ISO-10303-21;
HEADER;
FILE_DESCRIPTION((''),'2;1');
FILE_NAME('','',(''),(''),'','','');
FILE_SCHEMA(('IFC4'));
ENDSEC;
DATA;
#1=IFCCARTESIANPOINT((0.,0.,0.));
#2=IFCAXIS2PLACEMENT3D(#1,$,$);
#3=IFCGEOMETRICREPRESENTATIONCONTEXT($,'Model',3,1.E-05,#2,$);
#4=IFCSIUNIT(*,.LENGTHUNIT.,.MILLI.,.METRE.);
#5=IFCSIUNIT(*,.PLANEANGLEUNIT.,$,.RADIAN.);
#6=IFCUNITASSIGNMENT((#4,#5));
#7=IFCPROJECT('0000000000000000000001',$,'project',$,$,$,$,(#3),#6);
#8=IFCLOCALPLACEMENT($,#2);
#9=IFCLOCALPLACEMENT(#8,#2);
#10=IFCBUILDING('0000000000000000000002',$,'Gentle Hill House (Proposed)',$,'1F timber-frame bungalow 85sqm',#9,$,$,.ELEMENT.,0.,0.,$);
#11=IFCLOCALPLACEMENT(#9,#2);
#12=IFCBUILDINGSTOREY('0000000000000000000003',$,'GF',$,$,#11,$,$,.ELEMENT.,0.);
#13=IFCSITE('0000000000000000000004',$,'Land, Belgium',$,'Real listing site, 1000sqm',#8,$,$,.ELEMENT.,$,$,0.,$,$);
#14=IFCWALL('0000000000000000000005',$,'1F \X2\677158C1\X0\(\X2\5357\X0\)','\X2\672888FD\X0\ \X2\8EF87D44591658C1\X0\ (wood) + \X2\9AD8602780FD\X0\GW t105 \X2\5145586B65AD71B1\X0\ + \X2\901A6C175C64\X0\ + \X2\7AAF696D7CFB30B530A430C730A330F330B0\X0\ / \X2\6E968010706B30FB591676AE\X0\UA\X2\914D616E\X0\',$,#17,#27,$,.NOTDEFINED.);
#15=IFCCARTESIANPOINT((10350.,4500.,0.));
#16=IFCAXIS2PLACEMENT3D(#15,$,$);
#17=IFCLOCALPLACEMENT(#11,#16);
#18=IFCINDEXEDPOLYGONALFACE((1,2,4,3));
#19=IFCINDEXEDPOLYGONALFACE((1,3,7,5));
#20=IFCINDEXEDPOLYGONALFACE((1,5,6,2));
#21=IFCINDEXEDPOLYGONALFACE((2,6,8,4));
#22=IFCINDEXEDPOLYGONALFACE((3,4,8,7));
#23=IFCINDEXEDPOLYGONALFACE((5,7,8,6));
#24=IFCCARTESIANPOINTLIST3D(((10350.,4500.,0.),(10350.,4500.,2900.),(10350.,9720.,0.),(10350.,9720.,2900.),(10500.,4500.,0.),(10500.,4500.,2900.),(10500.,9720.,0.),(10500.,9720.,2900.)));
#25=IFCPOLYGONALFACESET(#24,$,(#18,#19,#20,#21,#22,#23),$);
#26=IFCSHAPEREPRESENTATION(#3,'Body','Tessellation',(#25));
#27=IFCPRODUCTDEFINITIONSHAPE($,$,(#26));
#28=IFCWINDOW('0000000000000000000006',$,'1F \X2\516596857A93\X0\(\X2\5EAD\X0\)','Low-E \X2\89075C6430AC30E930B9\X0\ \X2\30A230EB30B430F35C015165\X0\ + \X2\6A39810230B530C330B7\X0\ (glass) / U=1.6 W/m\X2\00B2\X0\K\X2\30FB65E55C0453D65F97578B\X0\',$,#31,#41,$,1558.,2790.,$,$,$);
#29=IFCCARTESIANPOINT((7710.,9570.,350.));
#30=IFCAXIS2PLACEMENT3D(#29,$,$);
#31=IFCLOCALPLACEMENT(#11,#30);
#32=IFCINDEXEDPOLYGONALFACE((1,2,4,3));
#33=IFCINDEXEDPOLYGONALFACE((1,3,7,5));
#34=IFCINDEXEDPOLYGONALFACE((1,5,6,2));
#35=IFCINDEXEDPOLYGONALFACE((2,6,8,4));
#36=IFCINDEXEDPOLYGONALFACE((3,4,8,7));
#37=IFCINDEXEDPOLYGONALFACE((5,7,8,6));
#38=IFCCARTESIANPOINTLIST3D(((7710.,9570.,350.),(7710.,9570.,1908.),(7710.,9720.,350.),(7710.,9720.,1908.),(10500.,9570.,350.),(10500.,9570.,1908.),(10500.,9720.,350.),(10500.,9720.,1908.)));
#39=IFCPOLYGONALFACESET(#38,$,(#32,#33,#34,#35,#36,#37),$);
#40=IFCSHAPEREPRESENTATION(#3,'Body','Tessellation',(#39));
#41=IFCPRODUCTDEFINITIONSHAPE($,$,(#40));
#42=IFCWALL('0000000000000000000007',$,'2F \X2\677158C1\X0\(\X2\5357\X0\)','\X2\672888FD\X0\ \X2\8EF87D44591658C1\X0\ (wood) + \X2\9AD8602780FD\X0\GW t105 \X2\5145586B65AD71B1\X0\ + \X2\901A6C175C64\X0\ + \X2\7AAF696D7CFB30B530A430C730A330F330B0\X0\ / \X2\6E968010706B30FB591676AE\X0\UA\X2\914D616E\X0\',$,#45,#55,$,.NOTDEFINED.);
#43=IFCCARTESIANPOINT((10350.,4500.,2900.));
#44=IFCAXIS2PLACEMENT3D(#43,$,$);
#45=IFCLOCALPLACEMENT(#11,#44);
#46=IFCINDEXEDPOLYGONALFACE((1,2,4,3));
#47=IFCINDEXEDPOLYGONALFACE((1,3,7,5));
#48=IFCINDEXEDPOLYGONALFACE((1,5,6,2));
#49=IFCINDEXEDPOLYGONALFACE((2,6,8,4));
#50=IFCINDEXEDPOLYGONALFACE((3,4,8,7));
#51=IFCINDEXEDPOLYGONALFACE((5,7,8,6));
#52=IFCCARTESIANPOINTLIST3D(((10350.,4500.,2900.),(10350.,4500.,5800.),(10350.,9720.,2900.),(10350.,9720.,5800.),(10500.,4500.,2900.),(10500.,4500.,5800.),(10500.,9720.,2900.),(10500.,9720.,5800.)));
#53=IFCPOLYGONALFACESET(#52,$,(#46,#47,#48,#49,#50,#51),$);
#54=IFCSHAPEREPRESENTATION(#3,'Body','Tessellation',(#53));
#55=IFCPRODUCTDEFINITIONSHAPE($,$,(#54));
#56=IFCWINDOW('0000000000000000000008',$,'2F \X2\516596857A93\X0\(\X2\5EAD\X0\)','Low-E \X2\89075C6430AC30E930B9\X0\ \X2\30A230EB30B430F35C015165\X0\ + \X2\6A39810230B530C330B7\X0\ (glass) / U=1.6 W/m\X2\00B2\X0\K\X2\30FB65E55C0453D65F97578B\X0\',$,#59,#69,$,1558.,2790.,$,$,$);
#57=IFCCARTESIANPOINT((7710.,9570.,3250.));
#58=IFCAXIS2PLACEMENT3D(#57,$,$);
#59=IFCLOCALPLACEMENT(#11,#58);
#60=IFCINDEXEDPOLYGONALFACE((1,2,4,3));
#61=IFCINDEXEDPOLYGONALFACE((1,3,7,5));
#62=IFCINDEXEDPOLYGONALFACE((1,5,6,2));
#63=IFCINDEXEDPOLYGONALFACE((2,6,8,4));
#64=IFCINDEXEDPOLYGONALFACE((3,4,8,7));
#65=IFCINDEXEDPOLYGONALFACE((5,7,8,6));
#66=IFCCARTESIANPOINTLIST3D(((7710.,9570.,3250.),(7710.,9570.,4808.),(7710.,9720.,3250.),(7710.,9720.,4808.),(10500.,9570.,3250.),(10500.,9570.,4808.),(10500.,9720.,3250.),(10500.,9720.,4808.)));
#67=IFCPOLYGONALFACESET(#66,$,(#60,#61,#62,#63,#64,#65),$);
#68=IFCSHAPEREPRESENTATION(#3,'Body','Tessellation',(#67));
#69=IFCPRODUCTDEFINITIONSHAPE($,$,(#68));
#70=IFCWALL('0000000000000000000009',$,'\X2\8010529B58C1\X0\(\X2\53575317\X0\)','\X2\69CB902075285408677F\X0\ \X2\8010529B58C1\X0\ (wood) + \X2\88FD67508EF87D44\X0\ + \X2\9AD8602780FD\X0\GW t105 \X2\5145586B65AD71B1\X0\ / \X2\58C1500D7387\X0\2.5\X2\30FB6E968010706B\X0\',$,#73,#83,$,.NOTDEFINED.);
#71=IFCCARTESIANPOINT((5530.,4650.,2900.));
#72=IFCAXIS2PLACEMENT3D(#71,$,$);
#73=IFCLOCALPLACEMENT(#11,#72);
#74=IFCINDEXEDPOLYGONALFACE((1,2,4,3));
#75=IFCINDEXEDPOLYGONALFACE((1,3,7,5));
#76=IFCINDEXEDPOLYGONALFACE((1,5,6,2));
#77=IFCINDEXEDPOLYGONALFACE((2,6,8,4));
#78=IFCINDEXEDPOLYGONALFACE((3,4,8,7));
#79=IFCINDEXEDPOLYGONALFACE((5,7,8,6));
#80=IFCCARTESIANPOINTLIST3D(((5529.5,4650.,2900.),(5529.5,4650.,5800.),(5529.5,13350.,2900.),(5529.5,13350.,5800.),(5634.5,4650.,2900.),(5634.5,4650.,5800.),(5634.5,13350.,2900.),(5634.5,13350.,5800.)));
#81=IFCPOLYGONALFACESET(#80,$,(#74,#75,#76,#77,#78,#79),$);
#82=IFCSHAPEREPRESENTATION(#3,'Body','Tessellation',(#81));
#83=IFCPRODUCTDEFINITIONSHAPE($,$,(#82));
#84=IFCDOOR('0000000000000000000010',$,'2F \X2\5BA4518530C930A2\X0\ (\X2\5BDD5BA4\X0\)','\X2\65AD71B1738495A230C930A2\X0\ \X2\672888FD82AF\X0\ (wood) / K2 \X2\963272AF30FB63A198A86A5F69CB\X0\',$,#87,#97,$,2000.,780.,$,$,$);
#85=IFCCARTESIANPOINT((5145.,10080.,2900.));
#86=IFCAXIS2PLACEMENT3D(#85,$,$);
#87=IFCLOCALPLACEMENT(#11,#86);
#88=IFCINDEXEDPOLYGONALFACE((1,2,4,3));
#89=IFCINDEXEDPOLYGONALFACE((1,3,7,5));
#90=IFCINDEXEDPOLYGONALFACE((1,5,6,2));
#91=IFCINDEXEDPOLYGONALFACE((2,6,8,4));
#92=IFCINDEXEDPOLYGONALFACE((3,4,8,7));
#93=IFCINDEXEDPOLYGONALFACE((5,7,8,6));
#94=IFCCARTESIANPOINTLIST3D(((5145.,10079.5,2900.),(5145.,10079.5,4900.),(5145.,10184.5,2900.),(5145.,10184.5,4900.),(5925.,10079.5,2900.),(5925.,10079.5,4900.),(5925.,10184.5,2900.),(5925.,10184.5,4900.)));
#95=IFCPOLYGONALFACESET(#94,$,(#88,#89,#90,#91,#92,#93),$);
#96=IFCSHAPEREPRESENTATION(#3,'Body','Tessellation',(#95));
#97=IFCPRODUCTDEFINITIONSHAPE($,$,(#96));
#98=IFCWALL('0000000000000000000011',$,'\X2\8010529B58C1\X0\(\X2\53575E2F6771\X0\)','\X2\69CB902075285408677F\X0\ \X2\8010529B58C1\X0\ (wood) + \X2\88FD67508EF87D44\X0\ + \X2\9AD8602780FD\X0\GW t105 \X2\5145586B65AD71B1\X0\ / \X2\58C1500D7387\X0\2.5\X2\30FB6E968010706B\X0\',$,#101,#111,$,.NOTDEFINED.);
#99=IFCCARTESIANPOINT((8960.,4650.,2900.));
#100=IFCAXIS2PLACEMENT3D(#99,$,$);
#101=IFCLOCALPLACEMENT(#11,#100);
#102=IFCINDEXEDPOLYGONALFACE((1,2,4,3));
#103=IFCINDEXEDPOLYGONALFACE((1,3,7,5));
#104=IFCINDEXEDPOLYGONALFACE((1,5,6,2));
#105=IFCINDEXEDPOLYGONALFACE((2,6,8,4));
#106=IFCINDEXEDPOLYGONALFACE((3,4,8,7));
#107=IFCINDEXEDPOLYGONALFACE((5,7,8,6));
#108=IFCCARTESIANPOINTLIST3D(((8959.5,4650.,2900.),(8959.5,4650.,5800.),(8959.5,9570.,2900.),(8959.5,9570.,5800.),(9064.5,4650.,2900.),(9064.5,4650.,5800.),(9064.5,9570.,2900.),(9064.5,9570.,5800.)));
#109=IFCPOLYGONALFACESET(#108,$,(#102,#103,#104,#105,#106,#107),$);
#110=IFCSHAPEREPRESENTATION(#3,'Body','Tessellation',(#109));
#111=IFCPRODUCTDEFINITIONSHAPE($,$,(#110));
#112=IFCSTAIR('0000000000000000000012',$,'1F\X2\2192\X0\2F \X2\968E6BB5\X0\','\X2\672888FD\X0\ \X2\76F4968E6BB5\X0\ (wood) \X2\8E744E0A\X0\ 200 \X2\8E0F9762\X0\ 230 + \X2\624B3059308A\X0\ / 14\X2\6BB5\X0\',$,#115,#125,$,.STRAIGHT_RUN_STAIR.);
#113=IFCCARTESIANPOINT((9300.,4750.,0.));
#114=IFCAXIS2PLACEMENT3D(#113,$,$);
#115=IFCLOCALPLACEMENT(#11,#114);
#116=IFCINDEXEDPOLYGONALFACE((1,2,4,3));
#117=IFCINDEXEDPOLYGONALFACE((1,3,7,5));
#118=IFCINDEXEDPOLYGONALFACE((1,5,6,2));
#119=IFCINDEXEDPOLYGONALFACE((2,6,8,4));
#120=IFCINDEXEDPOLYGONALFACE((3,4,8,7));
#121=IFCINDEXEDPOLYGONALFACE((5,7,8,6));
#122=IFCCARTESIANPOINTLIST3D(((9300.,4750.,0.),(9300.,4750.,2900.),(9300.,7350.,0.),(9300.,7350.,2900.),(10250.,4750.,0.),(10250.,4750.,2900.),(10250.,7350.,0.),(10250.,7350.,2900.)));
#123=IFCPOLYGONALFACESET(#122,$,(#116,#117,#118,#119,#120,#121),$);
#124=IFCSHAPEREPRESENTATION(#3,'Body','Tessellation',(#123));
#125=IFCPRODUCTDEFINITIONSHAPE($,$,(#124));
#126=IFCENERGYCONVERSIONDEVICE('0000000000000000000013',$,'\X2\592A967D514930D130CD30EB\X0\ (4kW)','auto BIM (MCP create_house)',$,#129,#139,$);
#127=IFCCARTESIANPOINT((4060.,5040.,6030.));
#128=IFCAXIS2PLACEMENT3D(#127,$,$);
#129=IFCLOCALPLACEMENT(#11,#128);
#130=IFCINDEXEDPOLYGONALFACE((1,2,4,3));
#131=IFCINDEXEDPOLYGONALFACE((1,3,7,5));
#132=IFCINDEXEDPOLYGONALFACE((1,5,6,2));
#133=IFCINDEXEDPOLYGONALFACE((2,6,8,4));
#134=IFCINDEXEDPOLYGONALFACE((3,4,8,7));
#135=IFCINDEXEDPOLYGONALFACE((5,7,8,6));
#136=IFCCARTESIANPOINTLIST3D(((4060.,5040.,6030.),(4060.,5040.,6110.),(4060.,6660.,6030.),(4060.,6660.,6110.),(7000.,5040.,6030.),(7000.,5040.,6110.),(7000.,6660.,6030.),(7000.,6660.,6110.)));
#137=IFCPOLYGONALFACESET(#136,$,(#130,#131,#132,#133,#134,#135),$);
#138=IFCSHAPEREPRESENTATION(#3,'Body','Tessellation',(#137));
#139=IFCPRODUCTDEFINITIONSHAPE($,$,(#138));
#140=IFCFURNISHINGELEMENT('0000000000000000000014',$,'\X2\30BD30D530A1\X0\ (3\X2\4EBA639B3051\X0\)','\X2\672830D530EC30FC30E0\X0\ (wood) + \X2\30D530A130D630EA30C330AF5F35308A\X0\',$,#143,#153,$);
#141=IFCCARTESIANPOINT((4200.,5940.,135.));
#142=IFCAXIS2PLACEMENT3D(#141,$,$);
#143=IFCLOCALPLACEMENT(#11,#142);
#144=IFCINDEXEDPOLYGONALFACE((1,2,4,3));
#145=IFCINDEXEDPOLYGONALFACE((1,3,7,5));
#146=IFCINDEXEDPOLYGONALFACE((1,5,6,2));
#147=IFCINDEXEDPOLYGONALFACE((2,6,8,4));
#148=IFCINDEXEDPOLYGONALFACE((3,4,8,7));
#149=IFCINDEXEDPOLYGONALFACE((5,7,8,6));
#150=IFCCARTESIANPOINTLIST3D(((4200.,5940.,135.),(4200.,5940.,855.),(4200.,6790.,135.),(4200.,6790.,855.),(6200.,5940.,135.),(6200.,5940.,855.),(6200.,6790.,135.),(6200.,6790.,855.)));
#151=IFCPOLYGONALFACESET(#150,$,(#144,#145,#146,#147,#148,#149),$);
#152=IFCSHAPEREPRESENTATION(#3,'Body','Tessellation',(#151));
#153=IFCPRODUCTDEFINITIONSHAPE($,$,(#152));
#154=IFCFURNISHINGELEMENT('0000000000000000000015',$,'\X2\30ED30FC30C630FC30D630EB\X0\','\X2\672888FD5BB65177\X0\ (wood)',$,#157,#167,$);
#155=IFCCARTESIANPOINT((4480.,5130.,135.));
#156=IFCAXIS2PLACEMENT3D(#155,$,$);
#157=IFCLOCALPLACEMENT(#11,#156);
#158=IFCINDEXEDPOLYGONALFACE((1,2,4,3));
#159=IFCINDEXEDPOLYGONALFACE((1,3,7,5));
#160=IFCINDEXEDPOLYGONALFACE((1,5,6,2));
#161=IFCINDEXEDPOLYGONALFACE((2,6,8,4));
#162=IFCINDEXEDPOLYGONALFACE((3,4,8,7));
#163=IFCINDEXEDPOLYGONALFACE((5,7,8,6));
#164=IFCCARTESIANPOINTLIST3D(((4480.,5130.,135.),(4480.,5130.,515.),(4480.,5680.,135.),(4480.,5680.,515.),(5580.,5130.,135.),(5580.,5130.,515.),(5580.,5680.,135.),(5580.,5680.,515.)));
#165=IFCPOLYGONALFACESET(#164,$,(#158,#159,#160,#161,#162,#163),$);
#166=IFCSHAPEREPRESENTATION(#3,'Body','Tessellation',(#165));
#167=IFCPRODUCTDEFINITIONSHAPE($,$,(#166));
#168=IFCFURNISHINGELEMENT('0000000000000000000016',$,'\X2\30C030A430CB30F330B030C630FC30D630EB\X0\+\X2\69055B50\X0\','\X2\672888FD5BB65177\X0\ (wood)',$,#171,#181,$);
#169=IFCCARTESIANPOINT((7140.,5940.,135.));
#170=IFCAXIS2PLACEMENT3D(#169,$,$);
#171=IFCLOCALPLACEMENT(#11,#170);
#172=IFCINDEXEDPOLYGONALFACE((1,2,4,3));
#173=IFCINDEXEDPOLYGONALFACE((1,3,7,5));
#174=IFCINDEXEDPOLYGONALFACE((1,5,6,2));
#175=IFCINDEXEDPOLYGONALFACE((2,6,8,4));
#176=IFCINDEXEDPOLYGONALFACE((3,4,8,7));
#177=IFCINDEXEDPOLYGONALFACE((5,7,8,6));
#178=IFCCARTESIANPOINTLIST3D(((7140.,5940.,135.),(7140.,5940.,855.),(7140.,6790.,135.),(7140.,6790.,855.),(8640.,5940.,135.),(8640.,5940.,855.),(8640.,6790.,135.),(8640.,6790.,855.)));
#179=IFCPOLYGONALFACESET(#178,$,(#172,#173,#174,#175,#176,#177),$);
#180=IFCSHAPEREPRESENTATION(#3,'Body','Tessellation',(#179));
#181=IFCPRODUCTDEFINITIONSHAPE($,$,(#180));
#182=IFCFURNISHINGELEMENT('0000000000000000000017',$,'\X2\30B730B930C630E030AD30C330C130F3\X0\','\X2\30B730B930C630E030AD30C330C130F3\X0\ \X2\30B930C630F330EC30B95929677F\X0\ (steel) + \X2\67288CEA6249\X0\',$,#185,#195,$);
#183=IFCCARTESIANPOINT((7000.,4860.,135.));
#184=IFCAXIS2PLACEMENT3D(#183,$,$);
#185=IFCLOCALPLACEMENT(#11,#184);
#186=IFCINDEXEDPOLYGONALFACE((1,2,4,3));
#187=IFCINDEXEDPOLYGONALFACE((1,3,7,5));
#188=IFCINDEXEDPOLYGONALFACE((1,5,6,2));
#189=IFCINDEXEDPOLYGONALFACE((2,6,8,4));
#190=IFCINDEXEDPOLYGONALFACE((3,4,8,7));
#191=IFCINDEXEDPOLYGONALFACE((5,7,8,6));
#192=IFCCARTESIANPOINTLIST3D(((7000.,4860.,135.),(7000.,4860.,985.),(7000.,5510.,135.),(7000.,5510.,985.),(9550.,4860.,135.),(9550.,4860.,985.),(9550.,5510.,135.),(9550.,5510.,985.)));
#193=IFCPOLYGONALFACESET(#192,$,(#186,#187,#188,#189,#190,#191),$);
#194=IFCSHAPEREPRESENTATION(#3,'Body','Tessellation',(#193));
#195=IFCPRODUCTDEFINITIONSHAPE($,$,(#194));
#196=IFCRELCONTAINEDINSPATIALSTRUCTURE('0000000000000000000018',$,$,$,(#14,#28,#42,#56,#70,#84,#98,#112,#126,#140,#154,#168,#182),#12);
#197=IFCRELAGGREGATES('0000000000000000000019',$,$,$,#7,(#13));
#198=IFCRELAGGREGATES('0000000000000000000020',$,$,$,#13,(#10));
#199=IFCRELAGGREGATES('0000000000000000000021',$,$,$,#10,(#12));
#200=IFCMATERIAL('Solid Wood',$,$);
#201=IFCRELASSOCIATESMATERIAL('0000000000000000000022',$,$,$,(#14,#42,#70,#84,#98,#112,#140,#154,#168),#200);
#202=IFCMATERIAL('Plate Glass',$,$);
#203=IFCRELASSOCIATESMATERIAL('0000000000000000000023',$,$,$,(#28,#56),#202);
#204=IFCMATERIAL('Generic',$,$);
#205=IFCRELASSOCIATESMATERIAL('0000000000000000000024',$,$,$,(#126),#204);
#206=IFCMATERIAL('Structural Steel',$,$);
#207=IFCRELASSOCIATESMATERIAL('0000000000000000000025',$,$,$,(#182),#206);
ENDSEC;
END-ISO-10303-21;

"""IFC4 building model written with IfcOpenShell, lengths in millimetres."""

from ifc_helpers import new_model, si_unit, frame, frame_2d, origin, place, context, project, spatial, rectangle, extrude, material, element, fill, save


model = new_model("IFC4")

# Units and contexts
model_context = context("Model", 3, precision=1e-05, world=origin())
ifc_project = project(units=[si_unit("LENGTHUNIT", "METRE", prefix="MILLI"), si_unit("PLANEANGLEUNIT", "RADIAN")], contexts=[model_context])

# Site, building, storey
site_placement = place(None, origin())
site = spatial("IfcSite", under=ifc_project, at=site_placement, Name="Land, Belgium", ObjectType="Real listing site, 1000sqm", CompositionType="ELEMENT", RefElevation=0.0)
building_placement = place(site_placement, origin())
building = spatial("IfcBuilding", under=site, at=building_placement, Name="Gentle Hill House (Proposed)", ObjectType="1F timber-frame bungalow 85sqm", CompositionType="ELEMENT", ElevationOfRefHeight=0.0, ElevationOfTerrain=0.0)
storey_placement = place(building_placement, origin())
storey = spatial("IfcBuildingStorey", under=building, at=storey_placement, Name="GF", CompositionType="ELEMENT", Elevation=0.0)

# Wall, opening, window
ifc_material_1 = material(Name="Solid Wood")
wall_1_placement = place(storey_placement, frame((10350.0, 4500.0, 0.0)))
wall_1 = element("IfcWall", 1, at=wall_1_placement, inside=storey, material=ifc_material_1, Name="1F 東壁(南)", Description="木製 軸組外壁 (wood) + 高性能GW t105 充填断熱 + 通気層 + 窯業系サイディング / 準耐火・外皮UA配慮", PredefinedType="NOTDEFINED", context=model_context, shape_type="SweptSolid", body=[
    extrude(rectangle(XDim=150.0, YDim=5220.0, at=frame_2d((75.0, 2610.0))), frame((10350.0, 4500.0, 0.0)), (0.0, 0.0, 1.0), 2900.0),
])
opening_1_placement = place(storey_placement, frame((7710.0, 9570.0, 350.0)))
opening_1 = element("IfcOpeningElement", 2, at=opening_1_placement, cuts=wall_1, PredefinedType="NOTDEFINED", context=model_context, shape_type="SweptSolid", body=[
    extrude(rectangle(XDim=2790.0, YDim=150.0, at=frame_2d((1395.0, 75.0))), frame((7710.0, 9570.0, 350.0)), (0.0, 0.0, 1.0), 1558.0),
])
ifc_material_2 = material(Name="Plate Glass")
window_1_placement = place(storey_placement, frame((7710.0, 9570.0, 350.0)))
window_1 = element("IfcWindow", 3, at=window_1_placement, inside=storey, material=ifc_material_2, Name="1F 入隅窓(庭)", Description="Low-E 複層ガラス アルゴン封入 + 樹脂サッシ (glass) / U=1.6 W/m²K・日射取得型", OverallHeight=1558.0, OverallWidth=2790.0, context=model_context, shape_type="SweptSolid", body=[
    extrude(rectangle(XDim=2790.0, YDim=150.0, at=frame_2d((1395.0, 75.0))), frame((7710.0, 9570.0, 350.0)), (0.0, 0.0, 1.0), 1558.0),
])
fill(opening_1, window_1)

# Wall, opening, window
wall_2_placement = place(storey_placement, frame((10350.0, 4500.0, 2900.0)))
wall_2 = element("IfcWall", 4, at=wall_2_placement, inside=storey, material=ifc_material_1, Name="2F 東壁(南)", Description="木製 軸組外壁 (wood) + 高性能GW t105 充填断熱 + 通気層 + 窯業系サイディング / 準耐火・外皮UA配慮", PredefinedType="NOTDEFINED", context=model_context, shape_type="SweptSolid", body=[
    extrude(rectangle(XDim=150.0, YDim=5220.0, at=frame_2d((75.0, 2610.0))), frame((10350.0, 4500.0, 2900.0)), (0.0, 0.0, 1.0), 2900.0),
])
opening_2_placement = place(storey_placement, frame((7710.0, 9570.0, 3250.0)))
opening_2 = element("IfcOpeningElement", 5, at=opening_2_placement, cuts=wall_2, PredefinedType="NOTDEFINED", context=model_context, shape_type="SweptSolid", body=[
    extrude(rectangle(XDim=2790.0, YDim=150.0, at=frame_2d((1395.0, 75.0))), frame((7710.0, 9570.0, 3250.0)), (0.0, 0.0, 1.0), 1558.0),
])
window_2_placement = place(storey_placement, frame((7710.0, 9570.0, 3250.0)))
window_2 = element("IfcWindow", 6, at=window_2_placement, inside=storey, material=ifc_material_2, Name="2F 入隅窓(庭)", Description="Low-E 複層ガラス アルゴン封入 + 樹脂サッシ (glass) / U=1.6 W/m²K・日射取得型", OverallHeight=1558.0, OverallWidth=2790.0, context=model_context, shape_type="SweptSolid", body=[
    extrude(rectangle(XDim=2790.0, YDim=150.0, at=frame_2d((1395.0, 75.0))), frame((7710.0, 9570.0, 3250.0)), (0.0, 0.0, 1.0), 1558.0),
])
fill(opening_2, window_2)

# Wall, opening, door
wall_3_placement = place(storey_placement, frame((5530.0, 4650.0, 2900.0)))
wall_3 = element("IfcWall", 7, at=wall_3_placement, inside=storey, material=ifc_material_1, Name="耐力壁(南北)", Description="構造用合板 耐力壁 (wood) + 製材軸組 + 高性能GW t105 充填断熱 / 壁倍率2.5・準耐火", PredefinedType="NOTDEFINED", context=model_context, shape_type="SweptSolid", body=[
    extrude(rectangle(XDim=105.0, YDim=8700.0, at=frame_2d((52.0, 4350.0))), frame((5530.0, 4650.0, 2900.0)), (0.0, 0.0, 1.0), 2900.0),
])
opening_3_placement = place(storey_placement, frame((5145.0, 10080.0, 2900.0)))
opening_3 = element("IfcOpeningElement", 8, at=opening_3_placement, cuts=wall_3, PredefinedType="NOTDEFINED", context=model_context, shape_type="SweptSolid", body=[
    extrude(rectangle(XDim=780.0, YDim=105.0, at=frame_2d((390.0, 52.0))), frame((5145.0, 10080.0, 2900.0)), (0.0, 0.0, 1.0), 2000.0),
])
door_1_placement = place(storey_placement, frame((5145.0, 10080.0, 2900.0)))
door_1 = element("IfcDoor", 9, at=door_1_placement, inside=storey, material=ifc_material_1, Name="2F 室内ドア (寝室)", Description="断熱玄関ドア 木製芯 (wood) / K2 防犯・採風機構", OverallHeight=2000.0, OverallWidth=780.0, context=model_context, shape_type="SweptSolid", body=[
    extrude(rectangle(XDim=780.0, YDim=105.0, at=frame_2d((390.0, 52.0))), frame((5145.0, 10080.0, 2900.0)), (0.0, 0.0, 1.0), 2000.0),
])
fill(opening_3, door_1)

# Wall
wall_4_placement = place(storey_placement, frame((8960.0, 4650.0, 2900.0)))
element("IfcWall", 10, at=wall_4_placement, inside=storey, material=ifc_material_1, Name="耐力壁(南帯東)", Description="構造用合板 耐力壁 (wood) + 製材軸組 + 高性能GW t105 充填断熱 / 壁倍率2.5・準耐火", PredefinedType="NOTDEFINED", context=model_context, shape_type="SweptSolid", body=[
    extrude(rectangle(XDim=105.0, YDim=4920.0, at=frame_2d((52.0, 2460.0))), frame((8960.0, 4650.0, 2900.0)), (0.0, 0.0, 1.0), 2900.0),
])

# Stair
stair_placement = place(storey_placement, frame((9300.0, 4750.0, 0.0)))
element("IfcStair", 11, at=stair_placement, inside=storey, material=ifc_material_1, Name="1F→2F 階段", Description="木製 直階段 (wood) 蹴上 200 踏面 230 + 手すり / 14段", PredefinedType="STRAIGHT_RUN_STAIR", context=model_context, shape_type="SweptSolid", body=[
    extrude(rectangle(XDim=950.0, YDim=2600.0, at=frame_2d((475.0, 1300.0))), frame((9300.0, 4750.0, 0.0)), (0.0, 0.0, 1.0), 2900.0),
])

# Energy conversion device
ifc_material_3 = material(Name="Generic")
energy_conversion_device_placement = place(storey_placement, frame((4060.0, 5040.0, 6030.0)))
element("IfcEnergyConversionDevice", 12, at=energy_conversion_device_placement, inside=storey, material=ifc_material_3, Name="太陽光パネル (4kW)", Description="auto BIM (MCP create_house)", context=model_context, shape_type="SweptSolid", body=[
    extrude(rectangle(XDim=2940.0, YDim=1620.0, at=frame_2d((1470.0, 810.0))), frame((4060.0, 5040.0, 6030.0)), (0.0, 0.0, 1.0), 80.0),
])

# Furnishing elements
furnishing_1_placement = place(storey_placement, frame((4200.0, 5940.0, 135.0)))
element("IfcFurnishingElement", 13, at=furnishing_1_placement, inside=storey, material=ifc_material_1, Name="ソファ (3人掛け)", Description="木フレーム (wood) + ファブリック張り", context=model_context, shape_type="SweptSolid", body=[
    extrude(rectangle(XDim=2000.0, YDim=850.0, at=frame_2d((1000.0, 425.0))), frame((4200.0, 5940.0, 135.0)), (0.0, 0.0, 1.0), 720.0),
])
furnishing_2_placement = place(storey_placement, frame((4480.0, 5130.0, 135.0)))
element("IfcFurnishingElement", 14, at=furnishing_2_placement, inside=storey, material=ifc_material_1, Name="ローテーブル", Description="木製家具 (wood)", context=model_context, shape_type="SweptSolid", body=[
    extrude(rectangle(XDim=1100.0, YDim=550.0, at=frame_2d((550.0, 275.0))), frame((4480.0, 5130.0, 135.0)), (0.0, 0.0, 1.0), 380.0),
])
furnishing_3_placement = place(storey_placement, frame((7140.0, 5940.0, 135.0)))
element("IfcFurnishingElement", 15, at=furnishing_3_placement, inside=storey, material=ifc_material_1, Name="ダイニングテーブル+椅子", Description="木製家具 (wood)", context=model_context, shape_type="SweptSolid", body=[
    extrude(rectangle(XDim=1500.0, YDim=850.0, at=frame_2d((750.0, 425.0))), frame((7140.0, 5940.0, 135.0)), (0.0, 0.0, 1.0), 720.0),
])
ifc_material_4 = material(Name="Structural Steel")
furnishing_4_placement = place(storey_placement, frame((7000.0, 4860.0, 135.0)))
element("IfcFurnishingElement", 16, at=furnishing_4_placement, inside=storey, material=ifc_material_4, Name="システムキッチン", Description="システムキッチン ステンレス天板 (steel) + 木質扉", context=model_context, shape_type="SweptSolid", body=[
    extrude(rectangle(XDim=2550.0, YDim=650.0, at=frame_2d((1275.0, 325.0))), frame((7000.0, 4860.0, 135.0)), (0.0, 0.0, 1.0), 850.0),
])

save(model, "model.ifc")
